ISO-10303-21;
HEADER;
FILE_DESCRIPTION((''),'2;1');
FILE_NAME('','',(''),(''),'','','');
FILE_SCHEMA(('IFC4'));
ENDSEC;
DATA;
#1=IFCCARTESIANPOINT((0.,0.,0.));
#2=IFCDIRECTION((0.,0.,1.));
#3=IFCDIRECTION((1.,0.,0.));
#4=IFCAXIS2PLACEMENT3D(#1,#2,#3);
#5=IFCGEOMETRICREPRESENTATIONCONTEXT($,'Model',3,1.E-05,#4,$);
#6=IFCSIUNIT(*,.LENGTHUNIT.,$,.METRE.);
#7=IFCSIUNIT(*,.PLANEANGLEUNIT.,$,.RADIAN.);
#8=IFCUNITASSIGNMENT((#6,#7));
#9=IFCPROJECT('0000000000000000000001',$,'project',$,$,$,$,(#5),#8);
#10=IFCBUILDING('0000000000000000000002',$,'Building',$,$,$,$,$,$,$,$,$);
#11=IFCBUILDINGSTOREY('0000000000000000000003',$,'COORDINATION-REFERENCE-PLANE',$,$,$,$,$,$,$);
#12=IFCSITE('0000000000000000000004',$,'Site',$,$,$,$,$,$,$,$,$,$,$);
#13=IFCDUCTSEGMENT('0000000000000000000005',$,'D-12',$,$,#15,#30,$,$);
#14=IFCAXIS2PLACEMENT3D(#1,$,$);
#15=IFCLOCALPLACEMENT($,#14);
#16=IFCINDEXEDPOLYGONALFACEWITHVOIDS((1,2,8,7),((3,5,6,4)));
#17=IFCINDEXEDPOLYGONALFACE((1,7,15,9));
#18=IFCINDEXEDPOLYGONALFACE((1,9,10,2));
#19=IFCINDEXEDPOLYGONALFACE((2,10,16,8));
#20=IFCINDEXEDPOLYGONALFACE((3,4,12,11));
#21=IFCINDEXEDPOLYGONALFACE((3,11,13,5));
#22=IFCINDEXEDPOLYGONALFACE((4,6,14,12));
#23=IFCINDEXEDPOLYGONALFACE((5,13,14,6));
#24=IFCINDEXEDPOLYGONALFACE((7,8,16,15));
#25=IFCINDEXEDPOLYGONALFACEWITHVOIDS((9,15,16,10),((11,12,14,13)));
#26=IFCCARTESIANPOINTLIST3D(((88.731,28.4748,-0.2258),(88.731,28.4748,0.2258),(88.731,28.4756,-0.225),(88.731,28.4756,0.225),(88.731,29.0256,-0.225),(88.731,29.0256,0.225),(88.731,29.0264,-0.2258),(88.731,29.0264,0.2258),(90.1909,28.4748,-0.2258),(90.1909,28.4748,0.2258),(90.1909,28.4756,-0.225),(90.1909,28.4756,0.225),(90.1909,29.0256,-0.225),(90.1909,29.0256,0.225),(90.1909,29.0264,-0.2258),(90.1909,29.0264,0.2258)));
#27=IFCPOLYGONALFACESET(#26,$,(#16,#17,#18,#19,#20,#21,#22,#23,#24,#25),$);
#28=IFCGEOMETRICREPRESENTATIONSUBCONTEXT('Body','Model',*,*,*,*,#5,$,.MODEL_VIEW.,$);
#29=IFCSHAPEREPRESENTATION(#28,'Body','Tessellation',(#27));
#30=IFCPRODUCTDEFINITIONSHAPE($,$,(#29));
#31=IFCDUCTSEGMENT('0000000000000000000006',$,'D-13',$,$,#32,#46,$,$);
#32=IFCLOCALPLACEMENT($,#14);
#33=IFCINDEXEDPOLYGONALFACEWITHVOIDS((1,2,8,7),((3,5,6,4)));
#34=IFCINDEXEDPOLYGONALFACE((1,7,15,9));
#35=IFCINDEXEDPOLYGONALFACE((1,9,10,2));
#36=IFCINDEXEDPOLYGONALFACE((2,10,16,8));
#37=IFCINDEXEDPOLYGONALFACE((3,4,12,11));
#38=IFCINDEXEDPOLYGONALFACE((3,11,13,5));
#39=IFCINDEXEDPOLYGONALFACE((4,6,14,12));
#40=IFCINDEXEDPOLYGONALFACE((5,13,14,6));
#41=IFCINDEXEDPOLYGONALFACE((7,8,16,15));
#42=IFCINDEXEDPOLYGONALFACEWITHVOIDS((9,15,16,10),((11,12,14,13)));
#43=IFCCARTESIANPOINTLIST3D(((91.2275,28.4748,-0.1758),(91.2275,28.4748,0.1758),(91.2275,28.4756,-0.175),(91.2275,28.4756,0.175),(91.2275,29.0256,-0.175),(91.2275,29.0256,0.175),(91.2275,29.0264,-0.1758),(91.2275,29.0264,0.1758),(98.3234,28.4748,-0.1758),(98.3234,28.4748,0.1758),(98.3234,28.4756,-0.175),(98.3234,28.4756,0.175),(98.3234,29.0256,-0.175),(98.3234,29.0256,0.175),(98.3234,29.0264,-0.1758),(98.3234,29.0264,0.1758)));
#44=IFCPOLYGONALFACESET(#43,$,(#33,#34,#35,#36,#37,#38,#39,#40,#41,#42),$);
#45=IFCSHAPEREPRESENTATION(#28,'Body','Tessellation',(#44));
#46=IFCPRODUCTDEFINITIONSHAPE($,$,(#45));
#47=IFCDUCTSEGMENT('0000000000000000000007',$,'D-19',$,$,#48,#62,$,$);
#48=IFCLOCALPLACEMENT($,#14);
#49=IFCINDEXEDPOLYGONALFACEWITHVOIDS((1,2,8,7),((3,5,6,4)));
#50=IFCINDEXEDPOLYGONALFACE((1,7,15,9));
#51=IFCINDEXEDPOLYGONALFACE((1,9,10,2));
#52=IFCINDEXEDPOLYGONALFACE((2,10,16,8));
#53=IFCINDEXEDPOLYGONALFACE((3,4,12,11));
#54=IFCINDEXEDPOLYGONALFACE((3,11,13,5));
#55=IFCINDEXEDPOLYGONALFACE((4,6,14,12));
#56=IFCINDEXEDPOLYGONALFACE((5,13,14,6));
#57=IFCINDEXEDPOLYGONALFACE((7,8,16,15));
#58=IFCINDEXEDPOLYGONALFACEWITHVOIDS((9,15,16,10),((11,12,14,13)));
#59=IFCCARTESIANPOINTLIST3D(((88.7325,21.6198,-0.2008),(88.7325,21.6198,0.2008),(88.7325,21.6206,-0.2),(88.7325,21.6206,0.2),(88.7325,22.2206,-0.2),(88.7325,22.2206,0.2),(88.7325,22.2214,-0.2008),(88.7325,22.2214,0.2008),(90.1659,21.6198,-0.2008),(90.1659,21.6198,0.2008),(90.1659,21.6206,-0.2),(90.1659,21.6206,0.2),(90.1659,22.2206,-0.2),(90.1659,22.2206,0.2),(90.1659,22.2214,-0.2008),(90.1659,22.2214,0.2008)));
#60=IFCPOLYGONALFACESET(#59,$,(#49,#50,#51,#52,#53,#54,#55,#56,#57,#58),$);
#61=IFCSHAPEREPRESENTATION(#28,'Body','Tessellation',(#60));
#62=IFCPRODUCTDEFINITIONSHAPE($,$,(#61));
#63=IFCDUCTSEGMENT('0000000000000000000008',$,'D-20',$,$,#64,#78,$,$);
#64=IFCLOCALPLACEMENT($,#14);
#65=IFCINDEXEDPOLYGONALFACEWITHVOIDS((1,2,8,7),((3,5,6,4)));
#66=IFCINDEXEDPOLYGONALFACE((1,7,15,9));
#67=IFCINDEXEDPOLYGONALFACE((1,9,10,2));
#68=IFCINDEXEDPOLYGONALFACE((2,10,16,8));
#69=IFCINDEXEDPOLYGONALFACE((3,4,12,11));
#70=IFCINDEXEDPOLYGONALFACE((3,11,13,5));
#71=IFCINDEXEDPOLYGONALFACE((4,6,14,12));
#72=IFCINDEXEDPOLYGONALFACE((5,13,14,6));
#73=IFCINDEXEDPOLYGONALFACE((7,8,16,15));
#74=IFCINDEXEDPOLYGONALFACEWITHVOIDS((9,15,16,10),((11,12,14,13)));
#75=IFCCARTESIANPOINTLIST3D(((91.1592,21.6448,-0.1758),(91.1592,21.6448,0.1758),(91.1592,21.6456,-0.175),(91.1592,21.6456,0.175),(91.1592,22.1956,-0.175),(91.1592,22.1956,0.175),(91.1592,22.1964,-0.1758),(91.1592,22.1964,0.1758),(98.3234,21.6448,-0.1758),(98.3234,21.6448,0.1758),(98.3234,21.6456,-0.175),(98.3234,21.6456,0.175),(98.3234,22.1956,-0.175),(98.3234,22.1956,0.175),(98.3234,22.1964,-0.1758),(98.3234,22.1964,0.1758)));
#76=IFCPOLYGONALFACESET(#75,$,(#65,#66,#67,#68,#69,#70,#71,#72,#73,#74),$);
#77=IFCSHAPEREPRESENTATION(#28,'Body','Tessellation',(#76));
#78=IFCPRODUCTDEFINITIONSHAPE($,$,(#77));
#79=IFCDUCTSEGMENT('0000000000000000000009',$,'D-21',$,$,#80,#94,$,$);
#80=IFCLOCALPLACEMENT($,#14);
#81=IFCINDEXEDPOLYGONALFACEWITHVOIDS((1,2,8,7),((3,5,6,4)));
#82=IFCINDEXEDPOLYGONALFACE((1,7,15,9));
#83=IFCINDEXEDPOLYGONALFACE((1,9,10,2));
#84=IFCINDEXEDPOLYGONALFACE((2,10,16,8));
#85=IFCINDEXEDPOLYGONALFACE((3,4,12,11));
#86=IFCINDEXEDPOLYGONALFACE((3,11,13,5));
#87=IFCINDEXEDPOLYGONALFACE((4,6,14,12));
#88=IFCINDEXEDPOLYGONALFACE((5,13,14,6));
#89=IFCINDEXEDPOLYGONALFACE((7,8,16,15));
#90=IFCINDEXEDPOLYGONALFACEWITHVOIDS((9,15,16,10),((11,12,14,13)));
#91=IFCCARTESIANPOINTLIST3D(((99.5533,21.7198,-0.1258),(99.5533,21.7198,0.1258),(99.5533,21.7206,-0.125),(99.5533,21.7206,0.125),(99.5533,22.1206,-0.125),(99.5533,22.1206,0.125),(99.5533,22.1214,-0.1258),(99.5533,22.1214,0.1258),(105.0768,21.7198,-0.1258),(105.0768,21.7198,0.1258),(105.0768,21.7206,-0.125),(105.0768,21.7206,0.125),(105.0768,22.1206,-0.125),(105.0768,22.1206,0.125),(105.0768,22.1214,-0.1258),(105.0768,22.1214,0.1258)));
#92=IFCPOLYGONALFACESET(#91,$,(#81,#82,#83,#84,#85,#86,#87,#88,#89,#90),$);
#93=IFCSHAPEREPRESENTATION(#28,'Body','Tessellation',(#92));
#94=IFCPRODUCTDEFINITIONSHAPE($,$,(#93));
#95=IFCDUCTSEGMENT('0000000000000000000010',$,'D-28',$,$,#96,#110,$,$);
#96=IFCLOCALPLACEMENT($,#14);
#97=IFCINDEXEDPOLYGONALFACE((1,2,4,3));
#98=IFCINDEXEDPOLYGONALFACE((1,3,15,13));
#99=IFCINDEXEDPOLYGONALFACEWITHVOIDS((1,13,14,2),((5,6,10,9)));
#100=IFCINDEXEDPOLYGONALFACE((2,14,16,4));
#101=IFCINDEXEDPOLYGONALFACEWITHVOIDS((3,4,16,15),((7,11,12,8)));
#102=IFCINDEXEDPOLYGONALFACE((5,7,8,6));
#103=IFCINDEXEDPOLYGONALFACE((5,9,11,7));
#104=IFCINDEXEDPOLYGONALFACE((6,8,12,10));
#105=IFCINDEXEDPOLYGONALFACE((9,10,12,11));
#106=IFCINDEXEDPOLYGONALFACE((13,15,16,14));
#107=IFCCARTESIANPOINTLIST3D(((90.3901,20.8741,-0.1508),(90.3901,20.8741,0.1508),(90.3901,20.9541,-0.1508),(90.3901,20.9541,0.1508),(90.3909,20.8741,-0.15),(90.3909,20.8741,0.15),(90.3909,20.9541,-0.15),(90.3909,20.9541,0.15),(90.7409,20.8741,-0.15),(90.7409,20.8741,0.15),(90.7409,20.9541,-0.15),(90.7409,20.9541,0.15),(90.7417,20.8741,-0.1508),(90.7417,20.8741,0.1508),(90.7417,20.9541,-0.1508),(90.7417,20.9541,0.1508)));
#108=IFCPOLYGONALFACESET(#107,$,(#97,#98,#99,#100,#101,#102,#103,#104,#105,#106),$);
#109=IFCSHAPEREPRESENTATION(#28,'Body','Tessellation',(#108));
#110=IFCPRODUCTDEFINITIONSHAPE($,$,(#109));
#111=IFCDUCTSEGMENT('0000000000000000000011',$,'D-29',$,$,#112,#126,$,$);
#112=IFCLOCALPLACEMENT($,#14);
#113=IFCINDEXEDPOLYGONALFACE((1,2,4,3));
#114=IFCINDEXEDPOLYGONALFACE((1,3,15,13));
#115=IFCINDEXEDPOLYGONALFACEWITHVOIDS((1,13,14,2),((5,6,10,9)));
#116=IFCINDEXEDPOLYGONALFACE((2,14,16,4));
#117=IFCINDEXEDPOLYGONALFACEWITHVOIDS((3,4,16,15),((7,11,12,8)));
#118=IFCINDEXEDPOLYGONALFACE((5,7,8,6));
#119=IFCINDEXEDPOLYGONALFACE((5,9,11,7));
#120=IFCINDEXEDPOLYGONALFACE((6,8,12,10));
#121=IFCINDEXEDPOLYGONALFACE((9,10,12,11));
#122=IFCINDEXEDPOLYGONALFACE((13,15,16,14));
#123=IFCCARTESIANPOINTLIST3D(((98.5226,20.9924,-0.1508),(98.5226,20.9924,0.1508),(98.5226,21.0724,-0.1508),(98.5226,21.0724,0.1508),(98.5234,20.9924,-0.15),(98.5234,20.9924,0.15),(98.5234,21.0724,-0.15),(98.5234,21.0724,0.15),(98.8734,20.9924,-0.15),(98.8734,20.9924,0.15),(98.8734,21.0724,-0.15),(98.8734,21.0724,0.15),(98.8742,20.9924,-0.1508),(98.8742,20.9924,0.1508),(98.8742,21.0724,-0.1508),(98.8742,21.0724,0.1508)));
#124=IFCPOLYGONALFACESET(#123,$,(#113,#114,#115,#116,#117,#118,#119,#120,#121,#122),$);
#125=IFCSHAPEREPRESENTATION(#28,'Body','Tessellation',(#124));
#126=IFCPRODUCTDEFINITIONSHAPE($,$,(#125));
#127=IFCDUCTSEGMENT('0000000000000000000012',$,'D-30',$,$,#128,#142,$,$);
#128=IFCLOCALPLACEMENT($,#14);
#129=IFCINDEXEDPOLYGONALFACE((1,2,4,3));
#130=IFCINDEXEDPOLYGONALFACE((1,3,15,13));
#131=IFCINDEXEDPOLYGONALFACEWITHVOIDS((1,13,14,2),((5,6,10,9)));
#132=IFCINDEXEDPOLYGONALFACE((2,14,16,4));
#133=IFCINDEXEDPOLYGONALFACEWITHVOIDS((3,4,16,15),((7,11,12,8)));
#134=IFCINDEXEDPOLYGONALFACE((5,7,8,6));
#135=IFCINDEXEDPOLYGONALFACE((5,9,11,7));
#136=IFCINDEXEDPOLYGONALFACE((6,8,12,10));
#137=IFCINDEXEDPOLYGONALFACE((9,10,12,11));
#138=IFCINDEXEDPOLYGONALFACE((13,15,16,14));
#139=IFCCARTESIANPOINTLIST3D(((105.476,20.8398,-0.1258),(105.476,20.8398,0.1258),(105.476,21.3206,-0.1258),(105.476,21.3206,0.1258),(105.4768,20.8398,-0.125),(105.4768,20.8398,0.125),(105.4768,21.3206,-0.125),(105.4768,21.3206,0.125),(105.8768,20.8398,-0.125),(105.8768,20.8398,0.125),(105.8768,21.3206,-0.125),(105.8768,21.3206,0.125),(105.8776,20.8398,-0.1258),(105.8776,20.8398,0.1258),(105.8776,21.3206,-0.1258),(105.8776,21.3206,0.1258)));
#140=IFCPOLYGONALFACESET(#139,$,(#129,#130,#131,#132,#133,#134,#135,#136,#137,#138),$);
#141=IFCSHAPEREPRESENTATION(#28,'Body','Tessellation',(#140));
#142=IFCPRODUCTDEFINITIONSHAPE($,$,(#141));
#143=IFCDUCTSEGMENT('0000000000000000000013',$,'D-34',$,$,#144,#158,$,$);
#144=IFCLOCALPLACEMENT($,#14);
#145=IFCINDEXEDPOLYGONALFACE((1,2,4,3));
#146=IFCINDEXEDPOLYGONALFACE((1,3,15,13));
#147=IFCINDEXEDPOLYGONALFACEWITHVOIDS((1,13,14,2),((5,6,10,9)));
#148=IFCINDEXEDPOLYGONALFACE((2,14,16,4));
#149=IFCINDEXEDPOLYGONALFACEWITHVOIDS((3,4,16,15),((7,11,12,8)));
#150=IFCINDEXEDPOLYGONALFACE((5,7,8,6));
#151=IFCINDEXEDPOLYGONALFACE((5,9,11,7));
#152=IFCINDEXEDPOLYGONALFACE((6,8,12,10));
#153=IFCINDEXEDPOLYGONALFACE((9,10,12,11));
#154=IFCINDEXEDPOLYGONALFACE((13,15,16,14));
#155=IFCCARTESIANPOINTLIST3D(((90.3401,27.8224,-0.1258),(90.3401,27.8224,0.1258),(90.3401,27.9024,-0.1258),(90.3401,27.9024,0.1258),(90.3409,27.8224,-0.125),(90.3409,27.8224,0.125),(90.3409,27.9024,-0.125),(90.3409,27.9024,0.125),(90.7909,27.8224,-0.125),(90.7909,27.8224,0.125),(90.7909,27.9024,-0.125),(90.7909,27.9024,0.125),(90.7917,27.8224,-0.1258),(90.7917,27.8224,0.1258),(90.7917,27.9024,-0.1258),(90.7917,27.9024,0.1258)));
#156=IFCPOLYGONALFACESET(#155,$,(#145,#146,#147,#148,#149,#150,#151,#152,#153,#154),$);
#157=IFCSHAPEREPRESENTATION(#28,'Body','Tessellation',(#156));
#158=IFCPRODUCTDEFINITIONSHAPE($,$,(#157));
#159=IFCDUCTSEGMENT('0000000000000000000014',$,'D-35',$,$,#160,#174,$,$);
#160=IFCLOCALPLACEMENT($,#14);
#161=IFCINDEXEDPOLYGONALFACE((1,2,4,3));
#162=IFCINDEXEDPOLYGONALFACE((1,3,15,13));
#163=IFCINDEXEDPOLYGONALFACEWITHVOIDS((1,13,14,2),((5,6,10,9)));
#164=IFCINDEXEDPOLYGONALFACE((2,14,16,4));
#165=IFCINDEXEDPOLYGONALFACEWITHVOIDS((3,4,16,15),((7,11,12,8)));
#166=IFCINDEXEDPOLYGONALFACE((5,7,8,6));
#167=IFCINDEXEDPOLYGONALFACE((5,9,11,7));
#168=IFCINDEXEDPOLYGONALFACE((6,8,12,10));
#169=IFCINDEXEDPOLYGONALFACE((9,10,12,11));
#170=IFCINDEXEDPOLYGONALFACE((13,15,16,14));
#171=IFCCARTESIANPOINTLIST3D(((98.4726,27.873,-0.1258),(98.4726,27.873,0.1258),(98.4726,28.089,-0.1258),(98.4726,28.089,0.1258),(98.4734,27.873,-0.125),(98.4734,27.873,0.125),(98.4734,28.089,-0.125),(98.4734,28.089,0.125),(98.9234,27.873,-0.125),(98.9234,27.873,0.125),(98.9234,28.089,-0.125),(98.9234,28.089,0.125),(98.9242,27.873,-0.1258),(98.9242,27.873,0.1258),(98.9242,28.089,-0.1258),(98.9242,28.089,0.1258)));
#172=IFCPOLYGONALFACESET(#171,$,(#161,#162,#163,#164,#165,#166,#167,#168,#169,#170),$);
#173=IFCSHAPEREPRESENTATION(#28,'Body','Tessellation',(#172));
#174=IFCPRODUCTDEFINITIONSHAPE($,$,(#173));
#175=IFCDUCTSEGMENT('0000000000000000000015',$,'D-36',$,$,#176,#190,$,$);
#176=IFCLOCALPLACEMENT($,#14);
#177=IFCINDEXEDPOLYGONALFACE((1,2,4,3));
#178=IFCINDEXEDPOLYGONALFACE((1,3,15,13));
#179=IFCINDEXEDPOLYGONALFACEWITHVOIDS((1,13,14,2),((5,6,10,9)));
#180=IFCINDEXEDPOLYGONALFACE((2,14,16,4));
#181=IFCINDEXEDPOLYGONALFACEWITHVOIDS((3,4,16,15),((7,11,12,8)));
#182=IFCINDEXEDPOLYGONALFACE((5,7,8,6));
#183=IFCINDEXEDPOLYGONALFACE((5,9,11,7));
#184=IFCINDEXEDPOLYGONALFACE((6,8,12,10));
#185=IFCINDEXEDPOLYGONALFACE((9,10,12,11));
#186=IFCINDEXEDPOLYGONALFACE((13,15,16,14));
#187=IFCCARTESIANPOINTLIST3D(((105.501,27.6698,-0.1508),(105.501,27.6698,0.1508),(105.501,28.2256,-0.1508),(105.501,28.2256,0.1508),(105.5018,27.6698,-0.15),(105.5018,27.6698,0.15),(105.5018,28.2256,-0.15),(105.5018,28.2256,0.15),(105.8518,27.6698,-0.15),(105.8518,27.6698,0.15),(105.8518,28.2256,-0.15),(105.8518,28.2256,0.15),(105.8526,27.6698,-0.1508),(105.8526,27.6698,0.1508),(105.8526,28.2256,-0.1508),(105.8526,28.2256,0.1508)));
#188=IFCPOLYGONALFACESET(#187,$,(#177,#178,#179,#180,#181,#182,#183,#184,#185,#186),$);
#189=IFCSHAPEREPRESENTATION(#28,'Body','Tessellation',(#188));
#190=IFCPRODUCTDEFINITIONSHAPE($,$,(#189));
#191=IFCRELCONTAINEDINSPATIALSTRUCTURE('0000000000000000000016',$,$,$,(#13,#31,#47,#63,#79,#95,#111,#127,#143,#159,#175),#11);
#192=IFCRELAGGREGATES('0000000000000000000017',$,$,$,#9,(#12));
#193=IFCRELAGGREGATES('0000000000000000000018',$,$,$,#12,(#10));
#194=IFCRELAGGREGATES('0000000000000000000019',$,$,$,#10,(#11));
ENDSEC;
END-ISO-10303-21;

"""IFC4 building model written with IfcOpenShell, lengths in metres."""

from ifc_helpers import new_model, si_unit, frame, origin, origin_with_axes, place, context, subcontext, project, spatial, hollow_rectangle, extrude, element, save


model = new_model("IFC4")

# Units and contexts
model_context = context("Model", 3, precision=1e-05, world=origin_with_axes())
body_context_1 = subcontext(model_context, "Body", "Model", "MODEL_VIEW")
ifc_project = project(units=[si_unit("LENGTHUNIT", "METRE"), si_unit("PLANEANGLEUNIT", "RADIAN")], contexts=[model_context])

# Site, building, storey
site = spatial("IfcSite", under=ifc_project, Name="Site")
building = spatial("IfcBuilding", under=site, Name="Building")
storey = spatial("IfcBuildingStorey", under=building, Name="COORDINATION-REFERENCE-PLANE")

# Duct segments
duct_segment_1_placement = place(None, frame((88.731, 28.7506, 0.0), z_axis=(1.0, 0.0, 0.0), x_axis=(0.0, 1.0, 0.0)))
element("IfcDuctSegment", 1, at=duct_segment_1_placement, inside=storey, Name="D-12", context=body_context_1, shape_type="SweptSolid", body=[
    extrude(hollow_rectangle(XDim=0.5516, YDim=0.4516, WallThickness=0.0008), origin(), (0.0, 0.0, 1.0), 1.4599),
])
duct_segment_2_placement = place(None, frame((91.2275, 28.7506, 0.0), z_axis=(1.0, 0.0, 0.0), x_axis=(0.0, 1.0, 0.0)))
element("IfcDuctSegment", 2, at=duct_segment_2_placement, inside=storey, Name="D-13", context=body_context_1, shape_type="SweptSolid", body=[
    extrude(hollow_rectangle(XDim=0.5516, YDim=0.3516, WallThickness=0.0008), origin(), (0.0, 0.0, 1.0), 7.0959),
])
duct_segment_3_placement = place(None, frame((88.7325, 21.9206, 0.0), z_axis=(1.0, 0.0, 0.0), x_axis=(0.0, 1.0, 0.0)))
element("IfcDuctSegment", 3, at=duct_segment_3_placement, inside=storey, Name="D-19", context=body_context_1, shape_type="SweptSolid", body=[
    extrude(hollow_rectangle(XDim=0.6016, YDim=0.4016, WallThickness=0.0008), origin(), (0.0, 0.0, 1.0), 1.4334),
])
duct_segment_4_placement = place(None, frame((91.1592, 21.9206, 0.0), z_axis=(1.0, 0.0, 0.0), x_axis=(0.0, 1.0, 0.0)))
element("IfcDuctSegment", 4, at=duct_segment_4_placement, inside=storey, Name="D-20", context=body_context_1, shape_type="SweptSolid", body=[
    extrude(hollow_rectangle(XDim=0.5516, YDim=0.3516, WallThickness=0.0008), origin(), (0.0, 0.0, 1.0), 7.1642),
])
duct_segment_5_placement = place(None, frame((99.5533, 21.9206, 0.0), z_axis=(1.0, 0.0, 0.0), x_axis=(0.0, 1.0, 0.0)))
element("IfcDuctSegment", 5, at=duct_segment_5_placement, inside=storey, Name="D-21", context=body_context_1, shape_type="SweptSolid", body=[
    extrude(hollow_rectangle(XDim=0.4016, YDim=0.2516, WallThickness=0.0008), origin(), (0.0, 0.0, 1.0), 5.5234),
])
for number, where, z_axis, x_axis, name in (
    (6, (90.5659, 20.8741, 0.0), (0.0, 1.0, 0.0), (1.0, 0.0, 0.0), "D-28"),
    (7, (98.6984, 20.9924, 0.0), (0.0, 1.0, 0.0), (1.0, 0.0, 0.0), "D-29"),
):
    element("IfcDuctSegment", number, at=place(None, frame(where, z_axis=z_axis, x_axis=x_axis)), inside=storey, Name=name, context=body_context_1, shape_type="SweptSolid", body=[
        extrude(hollow_rectangle(XDim=0.3516, YDim=0.3016, WallThickness=0.0008), origin(), (0.0, 0.0, 1.0), 0.08),
    ])
duct_segment_6_placement = place(None, frame((105.6768, 20.8398, 0.0), z_axis=(0.0, 1.0, 0.0), x_axis=(1.0, 0.0, 0.0)))
element("IfcDuctSegment", 8, at=duct_segment_6_placement, inside=storey, Name="D-30", context=body_context_1, shape_type="SweptSolid", body=[
    extrude(hollow_rectangle(XDim=0.4016, YDim=0.2516, WallThickness=0.0008), origin(), (0.0, 0.0, 1.0), 0.4808),
])
duct_segment_7_placement = place(None, frame((90.5659, 27.8224, 0.0), z_axis=(0.0, 1.0, 0.0), x_axis=(1.0, 0.0, 0.0)))
element("IfcDuctSegment", 9, at=duct_segment_7_placement, inside=storey, Name="D-34", context=body_context_1, shape_type="SweptSolid", body=[
    extrude(hollow_rectangle(XDim=0.4516, YDim=0.2516, WallThickness=0.0008), origin(), (0.0, 0.0, 1.0), 0.08),
])
duct_segment_8_placement = place(None, frame((98.6984, 27.873, 0.0), z_axis=(0.0, 1.0, 0.0), x_axis=(1.0, 0.0, 0.0)))
element("IfcDuctSegment", 10, at=duct_segment_8_placement, inside=storey, Name="D-35", context=body_context_1, shape_type="SweptSolid", body=[
    extrude(hollow_rectangle(XDim=0.4516, YDim=0.2516, WallThickness=0.0008), origin(), (0.0, 0.0, 1.0), 0.216),
])
duct_segment_9_placement = place(None, frame((105.6768, 27.6698, 0.0), z_axis=(0.0, 1.0, 0.0), x_axis=(1.0, 0.0, 0.0)))
element("IfcDuctSegment", 11, at=duct_segment_9_placement, inside=storey, Name="D-36", context=body_context_1, shape_type="SweptSolid", body=[
    extrude(hollow_rectangle(XDim=0.3516, YDim=0.3016, WallThickness=0.0008), origin(), (0.0, 0.0, 1.0), 0.5558),
])

save(model, "model.ifc")
